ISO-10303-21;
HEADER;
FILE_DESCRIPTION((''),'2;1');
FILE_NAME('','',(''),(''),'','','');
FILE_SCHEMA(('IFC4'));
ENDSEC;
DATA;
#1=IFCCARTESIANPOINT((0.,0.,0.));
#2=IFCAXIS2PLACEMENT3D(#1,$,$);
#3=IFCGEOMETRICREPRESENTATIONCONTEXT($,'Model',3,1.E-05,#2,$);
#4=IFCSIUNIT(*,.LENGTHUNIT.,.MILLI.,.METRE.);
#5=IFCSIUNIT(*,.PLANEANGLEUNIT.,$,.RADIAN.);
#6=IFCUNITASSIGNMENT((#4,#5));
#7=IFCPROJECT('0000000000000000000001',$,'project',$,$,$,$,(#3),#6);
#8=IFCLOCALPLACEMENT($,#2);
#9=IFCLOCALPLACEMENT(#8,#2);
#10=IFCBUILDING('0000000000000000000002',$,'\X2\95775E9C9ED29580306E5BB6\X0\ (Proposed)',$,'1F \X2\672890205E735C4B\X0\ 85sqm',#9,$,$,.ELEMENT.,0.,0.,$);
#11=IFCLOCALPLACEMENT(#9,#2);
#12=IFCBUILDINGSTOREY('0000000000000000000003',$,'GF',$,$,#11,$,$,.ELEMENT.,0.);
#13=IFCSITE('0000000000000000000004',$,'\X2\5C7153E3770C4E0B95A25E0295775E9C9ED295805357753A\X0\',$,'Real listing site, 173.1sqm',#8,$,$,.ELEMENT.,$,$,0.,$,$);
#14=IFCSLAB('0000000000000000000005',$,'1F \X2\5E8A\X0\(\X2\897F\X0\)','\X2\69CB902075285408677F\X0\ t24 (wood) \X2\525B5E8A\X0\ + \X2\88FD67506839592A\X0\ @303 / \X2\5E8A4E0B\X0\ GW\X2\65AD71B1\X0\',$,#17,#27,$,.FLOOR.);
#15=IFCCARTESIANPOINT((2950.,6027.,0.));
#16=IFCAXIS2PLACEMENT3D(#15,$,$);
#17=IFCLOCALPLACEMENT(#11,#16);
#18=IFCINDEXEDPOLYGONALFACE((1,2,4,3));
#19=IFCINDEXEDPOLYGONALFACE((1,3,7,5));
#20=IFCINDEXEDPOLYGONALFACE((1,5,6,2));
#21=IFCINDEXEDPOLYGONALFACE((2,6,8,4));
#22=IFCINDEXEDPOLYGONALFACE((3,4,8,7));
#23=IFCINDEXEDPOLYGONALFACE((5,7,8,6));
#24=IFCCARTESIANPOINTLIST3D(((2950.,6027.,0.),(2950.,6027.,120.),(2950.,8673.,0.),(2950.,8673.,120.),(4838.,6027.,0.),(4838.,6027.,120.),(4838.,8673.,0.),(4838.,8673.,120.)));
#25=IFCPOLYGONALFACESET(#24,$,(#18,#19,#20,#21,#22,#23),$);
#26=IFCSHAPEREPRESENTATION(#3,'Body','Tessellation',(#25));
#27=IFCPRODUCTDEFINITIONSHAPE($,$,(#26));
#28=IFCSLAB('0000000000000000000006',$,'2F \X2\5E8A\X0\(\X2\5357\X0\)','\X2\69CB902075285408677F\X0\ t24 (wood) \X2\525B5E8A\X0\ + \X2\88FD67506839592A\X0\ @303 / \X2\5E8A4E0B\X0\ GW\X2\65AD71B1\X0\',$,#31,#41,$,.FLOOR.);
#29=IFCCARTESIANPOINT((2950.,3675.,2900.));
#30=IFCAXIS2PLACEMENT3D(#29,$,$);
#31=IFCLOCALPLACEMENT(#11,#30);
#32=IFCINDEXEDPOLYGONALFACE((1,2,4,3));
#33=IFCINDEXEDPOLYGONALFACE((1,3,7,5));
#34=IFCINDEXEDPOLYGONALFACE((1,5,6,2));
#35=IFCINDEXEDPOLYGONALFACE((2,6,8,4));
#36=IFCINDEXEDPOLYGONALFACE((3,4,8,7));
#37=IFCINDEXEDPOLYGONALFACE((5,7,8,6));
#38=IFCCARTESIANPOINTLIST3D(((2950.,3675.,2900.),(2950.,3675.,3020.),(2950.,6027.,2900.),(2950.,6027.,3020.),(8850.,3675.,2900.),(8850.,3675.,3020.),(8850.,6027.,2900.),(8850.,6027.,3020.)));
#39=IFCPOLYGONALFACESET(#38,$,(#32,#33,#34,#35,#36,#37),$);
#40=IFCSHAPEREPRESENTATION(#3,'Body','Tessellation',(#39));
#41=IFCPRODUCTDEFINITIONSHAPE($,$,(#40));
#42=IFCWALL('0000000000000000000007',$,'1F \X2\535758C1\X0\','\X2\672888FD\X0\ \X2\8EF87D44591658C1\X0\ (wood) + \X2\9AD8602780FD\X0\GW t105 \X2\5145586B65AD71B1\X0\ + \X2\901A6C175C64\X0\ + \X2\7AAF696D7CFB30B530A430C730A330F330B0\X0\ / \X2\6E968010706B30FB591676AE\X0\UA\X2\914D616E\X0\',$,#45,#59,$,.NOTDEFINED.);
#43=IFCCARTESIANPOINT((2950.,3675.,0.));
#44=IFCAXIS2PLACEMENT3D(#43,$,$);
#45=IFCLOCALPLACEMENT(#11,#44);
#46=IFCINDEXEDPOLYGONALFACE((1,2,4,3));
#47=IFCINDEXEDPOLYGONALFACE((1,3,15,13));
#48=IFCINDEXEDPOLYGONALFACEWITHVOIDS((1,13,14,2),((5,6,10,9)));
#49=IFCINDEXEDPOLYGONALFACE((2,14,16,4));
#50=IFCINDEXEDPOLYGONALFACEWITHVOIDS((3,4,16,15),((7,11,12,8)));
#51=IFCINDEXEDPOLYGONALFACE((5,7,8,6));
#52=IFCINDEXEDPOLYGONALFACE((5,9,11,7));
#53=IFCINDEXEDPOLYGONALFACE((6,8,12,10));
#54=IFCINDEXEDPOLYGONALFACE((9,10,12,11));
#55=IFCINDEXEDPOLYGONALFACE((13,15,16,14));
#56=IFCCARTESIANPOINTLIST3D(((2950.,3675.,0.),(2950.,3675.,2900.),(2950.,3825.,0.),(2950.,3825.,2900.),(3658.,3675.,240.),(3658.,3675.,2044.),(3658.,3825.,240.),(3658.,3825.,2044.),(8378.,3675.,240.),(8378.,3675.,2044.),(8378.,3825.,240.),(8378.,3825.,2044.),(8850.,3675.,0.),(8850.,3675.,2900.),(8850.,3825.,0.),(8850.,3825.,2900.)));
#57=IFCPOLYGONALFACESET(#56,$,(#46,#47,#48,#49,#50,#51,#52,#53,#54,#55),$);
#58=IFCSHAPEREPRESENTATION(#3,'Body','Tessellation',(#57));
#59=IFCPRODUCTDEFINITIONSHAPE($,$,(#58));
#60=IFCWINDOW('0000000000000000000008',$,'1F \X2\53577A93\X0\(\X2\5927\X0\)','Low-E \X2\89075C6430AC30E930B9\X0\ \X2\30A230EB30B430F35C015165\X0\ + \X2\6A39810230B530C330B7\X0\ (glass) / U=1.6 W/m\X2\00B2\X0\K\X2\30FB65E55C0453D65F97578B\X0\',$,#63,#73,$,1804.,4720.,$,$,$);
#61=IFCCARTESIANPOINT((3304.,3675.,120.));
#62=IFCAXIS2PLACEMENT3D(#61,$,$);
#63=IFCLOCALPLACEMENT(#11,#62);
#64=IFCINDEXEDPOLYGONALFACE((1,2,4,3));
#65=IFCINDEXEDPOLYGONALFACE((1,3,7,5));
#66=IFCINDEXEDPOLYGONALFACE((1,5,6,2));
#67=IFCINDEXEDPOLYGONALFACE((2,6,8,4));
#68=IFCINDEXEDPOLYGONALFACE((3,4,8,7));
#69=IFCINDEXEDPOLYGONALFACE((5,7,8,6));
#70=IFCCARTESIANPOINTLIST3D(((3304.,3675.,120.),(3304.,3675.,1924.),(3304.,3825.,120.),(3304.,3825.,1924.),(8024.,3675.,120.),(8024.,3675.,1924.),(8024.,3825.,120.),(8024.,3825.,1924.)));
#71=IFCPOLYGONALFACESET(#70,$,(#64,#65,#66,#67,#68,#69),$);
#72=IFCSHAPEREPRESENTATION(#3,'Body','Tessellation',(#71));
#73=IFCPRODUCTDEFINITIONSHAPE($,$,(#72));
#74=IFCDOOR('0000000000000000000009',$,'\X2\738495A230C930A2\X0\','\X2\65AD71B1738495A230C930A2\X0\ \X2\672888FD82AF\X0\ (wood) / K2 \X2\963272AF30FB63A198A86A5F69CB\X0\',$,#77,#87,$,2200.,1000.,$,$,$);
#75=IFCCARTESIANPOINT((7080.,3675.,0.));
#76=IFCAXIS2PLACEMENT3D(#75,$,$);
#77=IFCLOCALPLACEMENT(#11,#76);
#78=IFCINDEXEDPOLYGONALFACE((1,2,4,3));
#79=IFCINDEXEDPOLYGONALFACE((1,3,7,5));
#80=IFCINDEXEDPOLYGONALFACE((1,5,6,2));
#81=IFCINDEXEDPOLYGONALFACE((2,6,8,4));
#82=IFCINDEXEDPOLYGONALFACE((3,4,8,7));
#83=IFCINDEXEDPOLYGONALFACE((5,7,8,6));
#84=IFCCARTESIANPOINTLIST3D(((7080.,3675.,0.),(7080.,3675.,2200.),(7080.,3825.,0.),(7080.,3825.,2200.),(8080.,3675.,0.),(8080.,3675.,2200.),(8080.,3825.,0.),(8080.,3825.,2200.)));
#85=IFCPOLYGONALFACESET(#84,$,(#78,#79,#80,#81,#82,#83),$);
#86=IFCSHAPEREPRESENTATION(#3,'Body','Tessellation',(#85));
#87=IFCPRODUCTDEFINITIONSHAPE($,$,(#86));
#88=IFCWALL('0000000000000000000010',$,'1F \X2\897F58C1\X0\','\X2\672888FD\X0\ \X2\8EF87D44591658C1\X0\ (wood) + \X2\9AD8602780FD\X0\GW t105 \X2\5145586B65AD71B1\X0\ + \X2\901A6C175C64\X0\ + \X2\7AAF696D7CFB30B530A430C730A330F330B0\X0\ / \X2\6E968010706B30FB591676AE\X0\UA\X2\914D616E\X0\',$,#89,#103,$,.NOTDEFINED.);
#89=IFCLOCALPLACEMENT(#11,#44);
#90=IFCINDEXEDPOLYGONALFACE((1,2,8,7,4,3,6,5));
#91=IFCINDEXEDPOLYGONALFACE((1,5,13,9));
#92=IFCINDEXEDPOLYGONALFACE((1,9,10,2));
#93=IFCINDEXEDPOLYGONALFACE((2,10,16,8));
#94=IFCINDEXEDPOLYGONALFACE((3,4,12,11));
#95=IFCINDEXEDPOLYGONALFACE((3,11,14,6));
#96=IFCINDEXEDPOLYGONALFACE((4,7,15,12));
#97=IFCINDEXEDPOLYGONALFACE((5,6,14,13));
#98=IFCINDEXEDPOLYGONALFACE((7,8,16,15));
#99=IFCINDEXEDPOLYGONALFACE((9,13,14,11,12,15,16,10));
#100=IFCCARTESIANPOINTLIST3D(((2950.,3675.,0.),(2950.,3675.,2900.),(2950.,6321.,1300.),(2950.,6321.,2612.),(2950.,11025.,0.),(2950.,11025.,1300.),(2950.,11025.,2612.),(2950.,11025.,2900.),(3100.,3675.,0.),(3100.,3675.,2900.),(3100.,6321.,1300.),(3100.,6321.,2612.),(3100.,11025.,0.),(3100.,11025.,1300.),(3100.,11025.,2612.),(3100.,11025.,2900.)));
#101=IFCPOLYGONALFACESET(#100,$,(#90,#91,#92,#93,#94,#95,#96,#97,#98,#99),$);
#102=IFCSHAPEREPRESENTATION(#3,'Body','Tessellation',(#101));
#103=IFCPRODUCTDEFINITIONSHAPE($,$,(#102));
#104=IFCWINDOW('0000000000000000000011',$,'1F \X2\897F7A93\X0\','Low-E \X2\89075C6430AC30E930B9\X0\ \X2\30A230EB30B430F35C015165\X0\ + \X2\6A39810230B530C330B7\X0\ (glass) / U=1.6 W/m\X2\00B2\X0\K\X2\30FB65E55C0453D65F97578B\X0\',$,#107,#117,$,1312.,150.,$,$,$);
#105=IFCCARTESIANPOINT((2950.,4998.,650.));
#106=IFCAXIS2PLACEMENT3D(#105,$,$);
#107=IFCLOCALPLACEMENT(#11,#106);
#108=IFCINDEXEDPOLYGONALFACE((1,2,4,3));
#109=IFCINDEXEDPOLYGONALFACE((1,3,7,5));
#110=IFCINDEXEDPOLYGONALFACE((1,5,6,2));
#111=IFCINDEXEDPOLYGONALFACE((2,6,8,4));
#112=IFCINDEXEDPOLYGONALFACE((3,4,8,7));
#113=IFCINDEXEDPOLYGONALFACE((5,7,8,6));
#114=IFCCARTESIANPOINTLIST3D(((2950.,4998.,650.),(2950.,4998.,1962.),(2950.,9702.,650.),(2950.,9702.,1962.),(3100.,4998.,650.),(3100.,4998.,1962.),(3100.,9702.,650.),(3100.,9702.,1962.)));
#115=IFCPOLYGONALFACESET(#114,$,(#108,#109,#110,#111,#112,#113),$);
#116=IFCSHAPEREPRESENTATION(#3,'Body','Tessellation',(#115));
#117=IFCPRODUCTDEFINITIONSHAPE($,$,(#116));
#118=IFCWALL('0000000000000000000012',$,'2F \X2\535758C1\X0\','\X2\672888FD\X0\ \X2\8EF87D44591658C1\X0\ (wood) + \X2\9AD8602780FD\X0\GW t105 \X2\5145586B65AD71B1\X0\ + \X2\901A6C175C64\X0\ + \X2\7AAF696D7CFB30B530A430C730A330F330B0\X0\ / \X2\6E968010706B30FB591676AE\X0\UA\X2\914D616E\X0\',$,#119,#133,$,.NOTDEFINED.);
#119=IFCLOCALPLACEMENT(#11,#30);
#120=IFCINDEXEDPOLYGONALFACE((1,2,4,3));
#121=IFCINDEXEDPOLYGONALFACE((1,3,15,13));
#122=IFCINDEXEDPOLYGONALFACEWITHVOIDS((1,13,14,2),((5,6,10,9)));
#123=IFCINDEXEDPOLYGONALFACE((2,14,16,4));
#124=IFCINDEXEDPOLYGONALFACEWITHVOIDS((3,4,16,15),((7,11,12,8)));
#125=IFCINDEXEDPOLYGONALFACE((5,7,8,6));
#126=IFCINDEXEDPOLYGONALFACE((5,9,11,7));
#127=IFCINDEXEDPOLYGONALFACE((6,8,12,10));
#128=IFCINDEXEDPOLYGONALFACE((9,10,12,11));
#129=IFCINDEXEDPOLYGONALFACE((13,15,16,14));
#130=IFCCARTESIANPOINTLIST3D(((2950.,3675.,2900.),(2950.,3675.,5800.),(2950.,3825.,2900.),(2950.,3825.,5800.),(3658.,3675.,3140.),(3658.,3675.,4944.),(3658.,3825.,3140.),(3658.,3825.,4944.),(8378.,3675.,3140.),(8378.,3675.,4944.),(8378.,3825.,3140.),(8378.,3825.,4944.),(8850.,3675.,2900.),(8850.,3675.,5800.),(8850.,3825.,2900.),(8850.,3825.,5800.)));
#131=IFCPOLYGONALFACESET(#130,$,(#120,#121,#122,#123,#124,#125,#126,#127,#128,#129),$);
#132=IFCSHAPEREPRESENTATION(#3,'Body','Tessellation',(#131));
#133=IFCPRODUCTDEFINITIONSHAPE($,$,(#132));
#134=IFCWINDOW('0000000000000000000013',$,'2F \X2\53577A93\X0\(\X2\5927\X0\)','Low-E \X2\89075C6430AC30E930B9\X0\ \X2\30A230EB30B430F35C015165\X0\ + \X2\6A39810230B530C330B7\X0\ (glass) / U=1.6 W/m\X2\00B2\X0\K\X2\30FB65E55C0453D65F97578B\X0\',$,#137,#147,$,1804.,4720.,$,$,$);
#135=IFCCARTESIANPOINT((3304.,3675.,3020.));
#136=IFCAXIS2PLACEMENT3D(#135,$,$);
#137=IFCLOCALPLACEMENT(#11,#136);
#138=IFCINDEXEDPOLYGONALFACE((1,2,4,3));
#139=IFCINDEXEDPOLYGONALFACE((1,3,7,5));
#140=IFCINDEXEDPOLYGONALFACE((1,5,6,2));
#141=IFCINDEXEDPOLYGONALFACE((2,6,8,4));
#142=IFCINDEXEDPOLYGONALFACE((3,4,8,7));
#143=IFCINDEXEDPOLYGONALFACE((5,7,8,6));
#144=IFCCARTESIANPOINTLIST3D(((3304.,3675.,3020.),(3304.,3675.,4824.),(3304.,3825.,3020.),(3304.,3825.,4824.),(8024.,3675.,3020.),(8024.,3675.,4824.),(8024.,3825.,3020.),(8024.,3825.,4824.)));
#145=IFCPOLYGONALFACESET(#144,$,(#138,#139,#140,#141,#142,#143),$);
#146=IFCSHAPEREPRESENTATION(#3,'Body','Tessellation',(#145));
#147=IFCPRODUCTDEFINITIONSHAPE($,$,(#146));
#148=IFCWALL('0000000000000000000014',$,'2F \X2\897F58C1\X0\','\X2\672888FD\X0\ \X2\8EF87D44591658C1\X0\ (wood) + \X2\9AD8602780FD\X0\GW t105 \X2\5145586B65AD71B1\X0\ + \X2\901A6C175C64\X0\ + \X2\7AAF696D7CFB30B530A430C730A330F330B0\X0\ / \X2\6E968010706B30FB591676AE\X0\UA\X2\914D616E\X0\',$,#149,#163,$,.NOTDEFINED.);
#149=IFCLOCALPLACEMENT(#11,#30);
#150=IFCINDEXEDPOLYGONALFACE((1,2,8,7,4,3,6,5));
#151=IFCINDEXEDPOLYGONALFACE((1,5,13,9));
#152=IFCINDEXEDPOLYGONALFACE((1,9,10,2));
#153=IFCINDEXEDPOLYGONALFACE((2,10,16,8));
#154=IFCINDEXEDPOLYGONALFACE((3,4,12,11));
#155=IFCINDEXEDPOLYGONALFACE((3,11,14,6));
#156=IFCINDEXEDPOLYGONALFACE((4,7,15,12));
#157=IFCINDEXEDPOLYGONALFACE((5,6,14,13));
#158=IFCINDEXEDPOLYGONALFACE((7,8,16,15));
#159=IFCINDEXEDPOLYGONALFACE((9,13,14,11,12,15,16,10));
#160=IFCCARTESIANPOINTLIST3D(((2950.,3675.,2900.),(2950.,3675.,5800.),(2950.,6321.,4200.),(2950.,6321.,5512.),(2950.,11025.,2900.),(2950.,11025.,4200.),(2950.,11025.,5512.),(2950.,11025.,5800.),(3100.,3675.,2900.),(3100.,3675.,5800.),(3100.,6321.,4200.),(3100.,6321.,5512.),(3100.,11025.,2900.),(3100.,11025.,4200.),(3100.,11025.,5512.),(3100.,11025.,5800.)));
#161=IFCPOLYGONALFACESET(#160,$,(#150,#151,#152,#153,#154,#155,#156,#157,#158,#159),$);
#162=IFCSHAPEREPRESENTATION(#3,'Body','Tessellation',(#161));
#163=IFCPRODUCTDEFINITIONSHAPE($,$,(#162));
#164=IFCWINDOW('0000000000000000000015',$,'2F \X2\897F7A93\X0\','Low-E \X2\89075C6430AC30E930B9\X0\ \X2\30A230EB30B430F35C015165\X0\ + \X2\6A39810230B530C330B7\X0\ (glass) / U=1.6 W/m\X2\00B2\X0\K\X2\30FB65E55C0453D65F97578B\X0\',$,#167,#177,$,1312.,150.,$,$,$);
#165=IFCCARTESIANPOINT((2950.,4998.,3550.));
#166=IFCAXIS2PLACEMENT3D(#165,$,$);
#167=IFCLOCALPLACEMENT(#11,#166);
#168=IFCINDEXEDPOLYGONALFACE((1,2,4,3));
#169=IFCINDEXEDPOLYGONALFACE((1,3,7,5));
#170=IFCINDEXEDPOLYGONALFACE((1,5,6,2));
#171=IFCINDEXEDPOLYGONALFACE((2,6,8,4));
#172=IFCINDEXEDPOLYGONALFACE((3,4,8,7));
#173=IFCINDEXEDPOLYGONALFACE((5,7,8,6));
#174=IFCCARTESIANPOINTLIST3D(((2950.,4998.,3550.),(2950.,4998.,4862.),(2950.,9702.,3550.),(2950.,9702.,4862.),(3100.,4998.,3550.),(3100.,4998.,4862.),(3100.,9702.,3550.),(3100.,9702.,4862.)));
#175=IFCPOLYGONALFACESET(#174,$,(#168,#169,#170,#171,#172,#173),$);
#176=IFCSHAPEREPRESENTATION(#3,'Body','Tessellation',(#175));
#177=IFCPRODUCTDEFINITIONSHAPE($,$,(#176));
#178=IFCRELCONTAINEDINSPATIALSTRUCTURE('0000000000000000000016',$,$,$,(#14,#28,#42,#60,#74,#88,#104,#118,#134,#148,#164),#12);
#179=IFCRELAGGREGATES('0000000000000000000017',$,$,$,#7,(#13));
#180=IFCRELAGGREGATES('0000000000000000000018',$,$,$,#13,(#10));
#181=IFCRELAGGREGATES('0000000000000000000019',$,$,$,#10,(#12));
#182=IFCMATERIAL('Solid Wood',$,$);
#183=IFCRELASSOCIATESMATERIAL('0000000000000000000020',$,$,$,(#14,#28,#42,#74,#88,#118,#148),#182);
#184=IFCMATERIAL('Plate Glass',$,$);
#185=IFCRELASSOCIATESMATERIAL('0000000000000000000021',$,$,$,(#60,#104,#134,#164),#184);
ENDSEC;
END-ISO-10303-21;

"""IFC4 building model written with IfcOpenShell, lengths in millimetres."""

from ifc_helpers import new_model, si_unit, frame, frame_2d, origin, place, context, project, spatial, rectangle, extrude, material, element, fill, save


model = new_model("IFC4")

# Units and contexts
model_context = context("Model", 3, precision=1e-05, world=origin())
ifc_project = project(units=[si_unit("LENGTHUNIT", "METRE", prefix="MILLI"), si_unit("PLANEANGLEUNIT", "RADIAN")], contexts=[model_context])

# Site, building, storey
site_placement = place(None, origin())
site = spatial("IfcSite", under=ifc_project, at=site_placement, Name="山口県下関市長府黒門南町", ObjectType="Real listing site, 173.1sqm", CompositionType="ELEMENT", RefElevation=0.0)
building_placement = place(site_placement, origin())
building = spatial("IfcBuilding", under=site, at=building_placement, Name="長府黒門の家 (Proposed)", ObjectType="1F 木造平屋 85sqm", CompositionType="ELEMENT", ElevationOfRefHeight=0.0, ElevationOfTerrain=0.0)
storey_placement = place(building_placement, origin())
storey = spatial("IfcBuildingStorey", under=building, at=storey_placement, Name="GF", CompositionType="ELEMENT", Elevation=0.0)

# Slabs
ifc_material_1 = material(Name="Solid Wood")
slab_1_placement = place(storey_placement, frame((2950.0, 6027.0, 0.0)))
element("IfcSlab", 1, at=slab_1_placement, inside=storey, material=ifc_material_1, Name="1F 床(西)", Description="構造用合板 t24 (wood) 剛床 + 製材根太 @303 / 床下 GW断熱", PredefinedType="FLOOR", context=model_context, shape_type="SweptSolid", body=[
    extrude(rectangle(XDim=1888.0, YDim=2646.0, at=frame_2d((944.0, 1323.0))), frame((2950.0, 6027.0, 0.0)), (0.0, 0.0, 1.0), 120.0),
])
slab_2_placement = place(storey_placement, frame((2950.0, 3675.0, 2900.0)))
element("IfcSlab", 2, at=slab_2_placement, inside=storey, material=ifc_material_1, Name="2F 床(南)", Description="構造用合板 t24 (wood) 剛床 + 製材根太 @303 / 床下 GW断熱", PredefinedType="FLOOR", context=model_context, shape_type="SweptSolid", body=[
    extrude(rectangle(XDim=5900.0, YDim=2352.0, at=frame_2d((2950.0, 1176.0))), frame((2950.0, 3675.0, 2900.0)), (0.0, 0.0, 1.0), 120.0),
])

# Wall, openings, window, door
wall_1_placement = place(storey_placement, frame((2950.0, 3675.0, 0.0)))
wall_1 = element("IfcWall", 3, at=wall_1_placement, inside=storey, material=ifc_material_1, Name="1F 南壁", Description="木製 軸組外壁 (wood) + 高性能GW t105 充填断熱 + 通気層 + 窯業系サイディング / 準耐火・外皮UA配慮", PredefinedType="NOTDEFINED", context=model_context, shape_type="SweptSolid", body=[
    extrude(rectangle(XDim=5900.0, YDim=150.0, at=frame_2d((2950.0, 75.0))), frame((2950.0, 3675.0, 0.0)), (0.0, 0.0, 1.0), 2900.0),
])
opening_1_placement = place(storey_placement, frame((3304.0, 3675.0, 120.0)))
opening_1 = element("IfcOpeningElement", 4, at=opening_1_placement, cuts=wall_1, PredefinedType="NOTDEFINED", context=model_context, shape_type="SweptSolid", body=[
    extrude(rectangle(XDim=4720.0, YDim=150.0, at=frame_2d((2360.0, 75.0))), frame((3304.0, 3675.0, 120.0)), (0.0, 0.0, 1.0), 1804.0),
])
opening_2_placement = place(storey_placement, frame((7080.0, 3675.0, 0.0)))
opening_2 = element("IfcOpeningElement", 5, at=opening_2_placement, cuts=wall_1, PredefinedType="NOTDEFINED", context=model_context, shape_type="SweptSolid", body=[
    extrude(rectangle(XDim=1000.0, YDim=150.0, at=frame_2d((500.0, 75.0))), frame((7080.0, 3675.0, 0.0)), (0.0, 0.0, 1.0), 2200.0),
])
ifc_material_2 = material(Name="Plate Glass")
window_1_placement = place(storey_placement, frame((3304.0, 3675.0, 120.0)))
window_1 = element("IfcWindow", 6, at=window_1_placement, inside=storey, material=ifc_material_2, Name="1F 南窓(大)", Description="Low-E 複層ガラス アルゴン封入 + 樹脂サッシ (glass) / U=1.6 W/m²K・日射取得型", OverallHeight=1804.0, OverallWidth=4720.0, context=model_context, shape_type="SweptSolid", body=[
    extrude(rectangle(XDim=4720.0, YDim=150.0, at=frame_2d((2360.0, 75.0))), frame((3304.0, 3675.0, 120.0)), (0.0, 0.0, 1.0), 1804.0),
])
fill(opening_1, window_1)
door_placement = place(storey_placement, frame((7080.0, 3675.0, 0.0)))
door = element("IfcDoor", 7, at=door_placement, inside=storey, material=ifc_material_1, Name="玄関ドア", Description="断熱玄関ドア 木製芯 (wood) / K2 防犯・採風機構", OverallHeight=2200.0, OverallWidth=1000.0, context=model_context, shape_type="SweptSolid", body=[
    extrude(rectangle(XDim=1000.0, YDim=150.0, at=frame_2d((500.0, 75.0))), frame((7080.0, 3675.0, 0.0)), (0.0, 0.0, 1.0), 2200.0),
])
fill(opening_2, door)

# Walls, openings, windows
wall_2_placement = place(storey_placement, frame((2950.0, 3675.0, 0.0)))
wall_2 = element("IfcWall", 8, at=wall_2_placement, inside=storey, material=ifc_material_1, Name="1F 西壁", Description="木製 軸組外壁 (wood) + 高性能GW t105 充填断熱 + 通気層 + 窯業系サイディング / 準耐火・外皮UA配慮", PredefinedType="NOTDEFINED", context=model_context, shape_type="SweptSolid", body=[
    extrude(rectangle(XDim=150.0, YDim=7350.0, at=frame_2d((75.0, 3675.0))), frame((2950.0, 3675.0, 0.0)), (0.0, 0.0, 1.0), 2900.0),
])
opening_3_placement = place(storey_placement, frame((2950.0, 4998.0, 650.0)))
opening_3 = element("IfcOpeningElement", 9, at=opening_3_placement, cuts=wall_2, PredefinedType="NOTDEFINED", context=model_context, shape_type="SweptSolid", body=[
    extrude(rectangle(XDim=150.0, YDim=4704.0, at=frame_2d((75.0, 2352.0))), frame((2950.0, 4998.0, 650.0)), (0.0, 0.0, 1.0), 1312.0),
])
window_2_placement = place(storey_placement, frame((2950.0, 4998.0, 650.0)))
window_2 = element("IfcWindow", 10, at=window_2_placement, inside=storey, material=ifc_material_2, Name="1F 西窓", Description="Low-E 複層ガラス アルゴン封入 + 樹脂サッシ (glass) / U=1.6 W/m²K・日射取得型", OverallHeight=1312.0, OverallWidth=150.0, context=model_context, shape_type="SweptSolid", body=[
    extrude(rectangle(XDim=150.0, YDim=4704.0, at=frame_2d((75.0, 2352.0))), frame((2950.0, 4998.0, 650.0)), (0.0, 0.0, 1.0), 1312.0),
])
fill(opening_3, window_2)
wall_3_placement = place(storey_placement, frame((2950.0, 3675.0, 2900.0)))
wall_3 = element("IfcWall", 11, at=wall_3_placement, inside=storey, material=ifc_material_1, Name="2F 南壁", Description="木製 軸組外壁 (wood) + 高性能GW t105 充填断熱 + 通気層 + 窯業系サイディング / 準耐火・外皮UA配慮", PredefinedType="NOTDEFINED", context=model_context, shape_type="SweptSolid", body=[
    extrude(rectangle(XDim=5900.0, YDim=150.0, at=frame_2d((2950.0, 75.0))), frame((2950.0, 3675.0, 2900.0)), (0.0, 0.0, 1.0), 2900.0),
])
opening_4_placement = place(storey_placement, frame((3304.0, 3675.0, 3020.0)))
opening_4 = element("IfcOpeningElement", 12, at=opening_4_placement, cuts=wall_3, PredefinedType="NOTDEFINED", context=model_context, shape_type="SweptSolid", body=[
    extrude(rectangle(XDim=4720.0, YDim=150.0, at=frame_2d((2360.0, 75.0))), frame((3304.0, 3675.0, 3020.0)), (0.0, 0.0, 1.0), 1804.0),
])
window_3_placement = place(storey_placement, frame((3304.0, 3675.0, 3020.0)))
window_3 = element("IfcWindow", 13, at=window_3_placement, inside=storey, material=ifc_material_2, Name="2F 南窓(大)", Description="Low-E 複層ガラス アルゴン封入 + 樹脂サッシ (glass) / U=1.6 W/m²K・日射取得型", OverallHeight=1804.0, OverallWidth=4720.0, context=model_context, shape_type="SweptSolid", body=[
    extrude(rectangle(XDim=4720.0, YDim=150.0, at=frame_2d((2360.0, 75.0))), frame((3304.0, 3675.0, 3020.0)), (0.0, 0.0, 1.0), 1804.0),
])
fill(opening_4, window_3)
wall_4_placement = place(storey_placement, frame((2950.0, 3675.0, 2900.0)))
wall_4 = element("IfcWall", 14, at=wall_4_placement, inside=storey, material=ifc_material_1, Name="2F 西壁", Description="木製 軸組外壁 (wood) + 高性能GW t105 充填断熱 + 通気層 + 窯業系サイディング / 準耐火・外皮UA配慮", PredefinedType="NOTDEFINED", context=model_context, shape_type="SweptSolid", body=[
    extrude(rectangle(XDim=150.0, YDim=7350.0, at=frame_2d((75.0, 3675.0))), frame((2950.0, 3675.0, 2900.0)), (0.0, 0.0, 1.0), 2900.0),
])
opening_5_placement = place(storey_placement, frame((2950.0, 4998.0, 3550.0)))
opening_5 = element("IfcOpeningElement", 15, at=opening_5_placement, cuts=wall_4, PredefinedType="NOTDEFINED", context=model_context, shape_type="SweptSolid", body=[
    extrude(rectangle(XDim=150.0, YDim=4704.0, at=frame_2d((75.0, 2352.0))), frame((2950.0, 4998.0, 3550.0)), (0.0, 0.0, 1.0), 1312.0),
])
window_4_placement = place(storey_placement, frame((2950.0, 4998.0, 3550.0)))
window_4 = element("IfcWindow", 16, at=window_4_placement, inside=storey, material=ifc_material_2, Name="2F 西窓", Description="Low-E 複層ガラス アルゴン封入 + 樹脂サッシ (glass) / U=1.6 W/m²K・日射取得型", OverallHeight=1312.0, OverallWidth=150.0, context=model_context, shape_type="SweptSolid", body=[
    extrude(rectangle(XDim=150.0, YDim=4704.0, at=frame_2d((75.0, 2352.0))), frame((2950.0, 4998.0, 3550.0)), (0.0, 0.0, 1.0), 1312.0),
])
fill(opening_5, window_4)

save(model, "model.ifc")
